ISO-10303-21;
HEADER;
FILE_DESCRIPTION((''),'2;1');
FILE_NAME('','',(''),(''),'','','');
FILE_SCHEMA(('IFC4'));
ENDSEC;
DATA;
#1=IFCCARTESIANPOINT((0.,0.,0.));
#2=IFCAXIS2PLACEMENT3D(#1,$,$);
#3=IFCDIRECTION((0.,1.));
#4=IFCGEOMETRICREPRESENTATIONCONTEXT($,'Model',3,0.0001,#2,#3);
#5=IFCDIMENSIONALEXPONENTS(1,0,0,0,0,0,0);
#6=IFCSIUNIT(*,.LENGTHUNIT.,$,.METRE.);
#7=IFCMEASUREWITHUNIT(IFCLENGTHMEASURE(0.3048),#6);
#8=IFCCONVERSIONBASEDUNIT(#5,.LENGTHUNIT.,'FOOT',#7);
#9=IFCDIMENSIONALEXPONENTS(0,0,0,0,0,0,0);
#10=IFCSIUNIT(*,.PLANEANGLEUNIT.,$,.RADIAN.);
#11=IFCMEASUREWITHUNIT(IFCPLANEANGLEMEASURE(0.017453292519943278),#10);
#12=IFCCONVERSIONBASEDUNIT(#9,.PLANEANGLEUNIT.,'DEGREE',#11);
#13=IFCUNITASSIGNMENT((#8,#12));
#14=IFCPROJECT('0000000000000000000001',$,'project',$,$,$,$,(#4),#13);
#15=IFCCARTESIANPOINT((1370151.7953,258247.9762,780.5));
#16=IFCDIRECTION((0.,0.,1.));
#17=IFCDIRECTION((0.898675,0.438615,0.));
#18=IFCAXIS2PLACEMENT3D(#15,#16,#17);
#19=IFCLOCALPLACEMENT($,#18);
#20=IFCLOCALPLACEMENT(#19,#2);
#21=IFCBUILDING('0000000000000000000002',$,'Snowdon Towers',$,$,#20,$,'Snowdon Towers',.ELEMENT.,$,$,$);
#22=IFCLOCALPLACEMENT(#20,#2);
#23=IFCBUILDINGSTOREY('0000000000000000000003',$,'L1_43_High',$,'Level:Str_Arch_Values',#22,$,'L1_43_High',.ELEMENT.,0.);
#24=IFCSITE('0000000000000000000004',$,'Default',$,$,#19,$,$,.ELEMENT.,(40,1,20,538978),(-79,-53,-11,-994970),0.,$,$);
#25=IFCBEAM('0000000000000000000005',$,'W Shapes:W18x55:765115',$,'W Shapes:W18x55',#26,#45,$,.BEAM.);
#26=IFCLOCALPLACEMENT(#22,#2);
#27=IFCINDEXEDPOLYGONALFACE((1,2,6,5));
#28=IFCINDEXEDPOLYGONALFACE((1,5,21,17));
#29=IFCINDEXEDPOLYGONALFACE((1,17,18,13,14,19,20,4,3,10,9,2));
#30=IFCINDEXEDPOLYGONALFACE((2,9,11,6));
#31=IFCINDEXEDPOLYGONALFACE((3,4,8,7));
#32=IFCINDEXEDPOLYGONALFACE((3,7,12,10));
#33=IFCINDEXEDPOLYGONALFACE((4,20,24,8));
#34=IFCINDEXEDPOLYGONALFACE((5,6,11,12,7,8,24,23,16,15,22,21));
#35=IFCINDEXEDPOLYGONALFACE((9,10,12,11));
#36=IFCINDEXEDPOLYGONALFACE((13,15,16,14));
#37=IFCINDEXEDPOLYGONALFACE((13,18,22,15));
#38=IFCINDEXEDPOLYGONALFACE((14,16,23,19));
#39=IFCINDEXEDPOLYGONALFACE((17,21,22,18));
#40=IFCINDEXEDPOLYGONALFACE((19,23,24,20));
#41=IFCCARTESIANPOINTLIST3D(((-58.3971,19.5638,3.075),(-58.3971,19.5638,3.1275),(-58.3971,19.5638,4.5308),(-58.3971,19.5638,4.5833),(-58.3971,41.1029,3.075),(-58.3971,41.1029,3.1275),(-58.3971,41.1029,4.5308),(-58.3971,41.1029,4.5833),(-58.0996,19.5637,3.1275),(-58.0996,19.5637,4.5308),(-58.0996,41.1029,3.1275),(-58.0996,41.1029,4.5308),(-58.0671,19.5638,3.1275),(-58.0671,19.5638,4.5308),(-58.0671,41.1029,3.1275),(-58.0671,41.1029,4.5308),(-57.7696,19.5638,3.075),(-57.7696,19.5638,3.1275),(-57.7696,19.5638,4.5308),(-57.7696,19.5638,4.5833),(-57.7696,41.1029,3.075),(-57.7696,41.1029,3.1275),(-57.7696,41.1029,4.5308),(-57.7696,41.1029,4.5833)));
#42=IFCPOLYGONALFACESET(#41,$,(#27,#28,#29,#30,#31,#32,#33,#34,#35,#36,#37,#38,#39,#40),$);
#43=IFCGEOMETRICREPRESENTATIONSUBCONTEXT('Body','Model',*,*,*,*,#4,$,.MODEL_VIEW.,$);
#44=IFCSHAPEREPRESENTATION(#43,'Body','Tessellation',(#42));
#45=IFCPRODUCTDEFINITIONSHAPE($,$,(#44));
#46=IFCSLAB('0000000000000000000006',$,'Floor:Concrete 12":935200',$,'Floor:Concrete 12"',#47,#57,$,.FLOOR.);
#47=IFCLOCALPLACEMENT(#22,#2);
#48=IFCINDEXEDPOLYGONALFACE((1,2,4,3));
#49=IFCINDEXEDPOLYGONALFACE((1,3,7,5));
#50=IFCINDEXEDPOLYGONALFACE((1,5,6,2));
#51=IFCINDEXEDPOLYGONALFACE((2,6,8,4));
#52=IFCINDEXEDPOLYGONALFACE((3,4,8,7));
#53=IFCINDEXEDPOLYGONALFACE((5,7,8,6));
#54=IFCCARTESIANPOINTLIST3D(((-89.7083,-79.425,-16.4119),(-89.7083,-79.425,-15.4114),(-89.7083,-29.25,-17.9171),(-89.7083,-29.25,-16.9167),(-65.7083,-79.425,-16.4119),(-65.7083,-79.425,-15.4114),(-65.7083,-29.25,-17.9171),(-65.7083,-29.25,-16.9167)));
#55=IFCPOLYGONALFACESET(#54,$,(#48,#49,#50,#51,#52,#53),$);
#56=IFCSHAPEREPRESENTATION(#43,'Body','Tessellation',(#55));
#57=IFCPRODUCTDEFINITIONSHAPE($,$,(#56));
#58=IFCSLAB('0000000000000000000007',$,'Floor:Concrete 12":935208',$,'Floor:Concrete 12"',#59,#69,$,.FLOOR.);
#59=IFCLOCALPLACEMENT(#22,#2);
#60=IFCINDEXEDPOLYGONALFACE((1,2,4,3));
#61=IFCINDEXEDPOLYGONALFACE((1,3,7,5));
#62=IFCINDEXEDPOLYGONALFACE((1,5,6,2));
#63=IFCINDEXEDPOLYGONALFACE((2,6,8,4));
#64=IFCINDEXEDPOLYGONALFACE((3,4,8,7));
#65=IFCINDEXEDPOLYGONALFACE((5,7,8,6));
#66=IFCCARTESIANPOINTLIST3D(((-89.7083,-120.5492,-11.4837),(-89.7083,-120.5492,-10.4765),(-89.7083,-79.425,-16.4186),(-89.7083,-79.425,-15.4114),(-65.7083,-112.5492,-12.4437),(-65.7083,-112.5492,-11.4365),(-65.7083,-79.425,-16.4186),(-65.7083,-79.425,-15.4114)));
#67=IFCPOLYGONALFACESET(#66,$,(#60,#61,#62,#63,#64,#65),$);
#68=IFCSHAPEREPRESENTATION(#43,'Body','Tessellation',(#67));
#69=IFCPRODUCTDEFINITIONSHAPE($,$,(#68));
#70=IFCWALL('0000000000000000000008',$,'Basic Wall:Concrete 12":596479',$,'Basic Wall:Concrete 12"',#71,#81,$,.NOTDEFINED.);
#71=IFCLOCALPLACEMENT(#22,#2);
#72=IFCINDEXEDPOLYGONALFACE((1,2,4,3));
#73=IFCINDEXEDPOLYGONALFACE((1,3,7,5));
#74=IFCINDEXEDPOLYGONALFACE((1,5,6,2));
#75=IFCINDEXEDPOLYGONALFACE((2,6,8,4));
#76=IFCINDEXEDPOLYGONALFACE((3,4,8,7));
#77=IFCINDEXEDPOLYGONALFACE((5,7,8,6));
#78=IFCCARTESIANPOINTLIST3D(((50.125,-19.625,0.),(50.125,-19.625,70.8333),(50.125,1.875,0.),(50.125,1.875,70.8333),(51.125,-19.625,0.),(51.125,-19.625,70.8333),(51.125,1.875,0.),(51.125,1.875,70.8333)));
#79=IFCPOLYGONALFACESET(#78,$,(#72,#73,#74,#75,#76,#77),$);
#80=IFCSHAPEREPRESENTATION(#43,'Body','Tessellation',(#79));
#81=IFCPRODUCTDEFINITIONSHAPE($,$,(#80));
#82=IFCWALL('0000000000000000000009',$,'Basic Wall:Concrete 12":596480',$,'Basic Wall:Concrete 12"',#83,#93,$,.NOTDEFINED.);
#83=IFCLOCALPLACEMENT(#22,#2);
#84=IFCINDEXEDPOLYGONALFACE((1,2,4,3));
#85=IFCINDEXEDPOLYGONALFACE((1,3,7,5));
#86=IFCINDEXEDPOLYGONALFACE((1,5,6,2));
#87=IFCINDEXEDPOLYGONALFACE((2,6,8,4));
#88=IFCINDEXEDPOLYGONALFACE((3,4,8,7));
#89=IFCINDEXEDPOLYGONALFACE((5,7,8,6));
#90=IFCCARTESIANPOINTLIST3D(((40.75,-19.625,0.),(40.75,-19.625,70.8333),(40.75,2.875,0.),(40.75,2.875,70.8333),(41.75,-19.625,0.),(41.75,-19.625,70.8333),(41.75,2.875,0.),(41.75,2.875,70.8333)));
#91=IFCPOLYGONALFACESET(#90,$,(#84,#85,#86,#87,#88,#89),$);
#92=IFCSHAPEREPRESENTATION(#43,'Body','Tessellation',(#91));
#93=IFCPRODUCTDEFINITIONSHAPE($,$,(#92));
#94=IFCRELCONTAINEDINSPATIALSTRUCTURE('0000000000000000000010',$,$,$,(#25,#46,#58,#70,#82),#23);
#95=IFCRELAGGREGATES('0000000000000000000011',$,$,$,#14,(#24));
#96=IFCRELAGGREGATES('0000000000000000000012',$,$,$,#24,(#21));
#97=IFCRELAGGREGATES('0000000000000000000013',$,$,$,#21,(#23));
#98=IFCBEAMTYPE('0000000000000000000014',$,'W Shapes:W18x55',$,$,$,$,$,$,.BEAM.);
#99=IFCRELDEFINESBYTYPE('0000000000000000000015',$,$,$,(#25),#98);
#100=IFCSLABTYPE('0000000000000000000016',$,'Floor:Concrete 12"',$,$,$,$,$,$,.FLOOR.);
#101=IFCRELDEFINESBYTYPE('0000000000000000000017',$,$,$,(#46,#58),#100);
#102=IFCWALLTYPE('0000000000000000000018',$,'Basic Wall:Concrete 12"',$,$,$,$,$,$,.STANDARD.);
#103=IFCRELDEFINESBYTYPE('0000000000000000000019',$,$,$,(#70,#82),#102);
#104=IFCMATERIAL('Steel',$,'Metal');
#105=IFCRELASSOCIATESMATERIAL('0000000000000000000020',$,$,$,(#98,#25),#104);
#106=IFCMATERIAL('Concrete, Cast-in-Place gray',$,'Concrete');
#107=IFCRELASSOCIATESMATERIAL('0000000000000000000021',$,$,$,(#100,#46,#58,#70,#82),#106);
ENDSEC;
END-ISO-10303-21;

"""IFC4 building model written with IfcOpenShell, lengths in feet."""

from ifc_helpers import new_model, entity, si_unit, converted_unit, direction, frame, frame_2d, origin, place, context, subcontext, project, spatial, polyline, indexed_curve, rectangle, outline, extrude, source, transform, mapped, material, type_object, type_shapes, element, save


model = new_model("IFC4")

# Units and contexts
model_context = context("Model", 3, precision=0.0001, world=origin(), true_north=direction((0.0, 1.0)))
body_context = subcontext(model_context, "Body", "Model", "MODEL_VIEW")
ifc_project = project(units=[converted_unit("LENGTHUNIT", "FOOT", entity("IfcLengthMeasure", 0.3048), si_unit("LENGTHUNIT", "METRE"), dimensions=[1, 0, 0, 0, 0, 0, 0]), converted_unit("PLANEANGLEUNIT", "DEGREE", entity("IfcPlaneAngleMeasure", 0.017453292519943278), si_unit("PLANEANGLEUNIT", "RADIAN"), dimensions=[0, 0, 0, 0, 0, 0, 0])], contexts=[model_context])

# Site, building, storey
site_placement = place(None, frame((1370151.7953, 258247.9762, 780.5), z_axis=(0.0, 0.0, 1.0), x_axis=(0.898675, 0.438615, 0.0)))
site = spatial("IfcSite", under=ifc_project, at=site_placement, Name="Default", CompositionType="ELEMENT", RefLatitude=(40, 1, 20, 538978), RefLongitude=(-79, -53, -11, -994970), RefElevation=0.0)
building_placement = place(site_placement, origin())
building = spatial("IfcBuilding", under=site, at=building_placement, Name="Snowdon Towers", LongName="Snowdon Towers", CompositionType="ELEMENT")
storey_placement = place(building_placement, origin())
storey = spatial("IfcBuildingStorey", under=building, at=storey_placement, Name="L1_43_High", ObjectType="Level:Str_Arch_Values", LongName="L1_43_High", CompositionType="ELEMENT", Elevation=0.0)

# Shared definitions
ifc_material_1 = material(Name="Steel", Category="Metal")

# Shared definitions
ifc_material_2 = material(Name="Concrete, Cast-in-Place gray", Category="Concrete")

# Beam
beam_type_1 = type_object("IfcBeamType", Name="W Shapes:W18x55", PredefinedType="BEAM", material=ifc_material_1)
shared_shape_1 = source(origin(), body_context, "Body", "SweptSolid", [
    extrude(outline(indexed_curve([(-0.3138, -0.7017), (-0.3138, -0.7542), (0.3138, -0.7542), (0.3138, -0.7017), (0.0162, -0.7017), (0.0162, 0.7017), (0.3138, 0.7017), (0.3138, 0.7542), (-0.3137, 0.7542), (-0.3137, 0.7017), (-0.0163, 0.7017), (-0.0163, -0.7017), (-0.3138, -0.7017)], self_intersect=False)), frame((-10.7696, 0.0, 0.0), z_axis=(-1.0, 0.0, 0.0), x_axis=(0.0, -1.0, 0.0)), (0.0, 0.0, -1.0), 21.5392),
])
type_shapes(beam_type_1, [shared_shape_1])
beam_1_placement = place(storey_placement, frame((-58.0833, 30.3333, 3.8292), z_axis=(0.0, 0.0, 1.0), x_axis=(0.0, 1.0, 0.0)))
element("IfcBeam", 1, at=beam_1_placement, inside=storey, type_object=beam_type_1, material=ifc_material_1, Name="W Shapes:W18x55:765115", ObjectType="W Shapes:W18x55", PredefinedType="BEAM", context=body_context, shape_type="MappedRepresentation", body=[
    mapped(shared_shape_1, transform((0.0, 0.0, 0.0), scale=1.0)),
])

# Slabs
slab_type_1 = type_object("IfcSlabType", Name="Floor:Concrete 12\"", PredefinedType="FLOOR", material=ifc_material_2)
slab_1_placement = place(storey_placement, frame((-89.7083, -79.425, -17.9171)))
element("IfcSlab", 2, at=slab_1_placement, inside=storey, type_object=slab_type_1, material=ifc_material_2, Name="Floor:Concrete 12\":935200", ObjectType="Floor:Concrete 12\"", PredefinedType="FLOOR", context=body_context, shape_type="SweptSolid", body=[
    extrude(rectangle(XDim=24.0, YDim=50.1976, at=frame_2d((0.0, -25.0988), x_axis=(1.0, 0.0))), frame((12.0, 50.175, 1.0004), z_axis=(0.0, 0.029987, 0.99955), x_axis=(1.0, 0.0, 0.0)), (0.0, 0.029987, -0.99955), 1.0004),
])
slab_2_placement = place(storey_placement, frame((-89.7083, -120.5492, -16.4186)))
element("IfcSlab", 3, at=slab_2_placement, inside=storey, type_object=slab_type_1, material=ifc_material_2, Name="Floor:Concrete 12\":935208", ObjectType="Floor:Concrete 12\"", PredefinedType="FLOOR", context=body_context, shape_type="SweptSolid", body=[
    extrude(outline(polyline([(-12.0, -41.4193), (12.0, -33.3619), (12.0, 0.0), (-12.0, 0.0), (-12.0, -41.4193)])), frame((12.0, 41.1242, 1.0072), z_axis=(0.0, 0.119145, 0.992877), x_axis=(1.0, 0.0, 0.0)), (0.0, 0.119145, -0.992877), 1.0072),
])

# Walls
wall_type = type_object("IfcWallType", Name="Basic Wall:Concrete 12\"", PredefinedType="STANDARD")
wall_1_placement = place(storey_placement, frame((50.625, -19.625, 0.0), z_axis=(0.0, 0.0, 1.0), x_axis=(0.0, 1.0, 0.0)))
element("IfcWall", 4, at=wall_1_placement, inside=storey, type_object=wall_type, material=ifc_material_2, Name="Basic Wall:Concrete 12\":596479", ObjectType="Basic Wall:Concrete 12\"", PredefinedType="NOTDEFINED", context=body_context, shape_type="SweptSolid", body=[
    extrude(outline(indexed_curve([(21.5, 0.5), (0.0, 0.5), (0.0, -0.5), (21.5, -0.5), (21.5, 0.5)], self_intersect=False)), origin(), (0.0, 0.0, 1.0), 70.8333),
])
wall_2_placement = place(storey_placement, frame((41.25, 2.875, 0.0), z_axis=(0.0, 0.0, 1.0), x_axis=(0.0, -1.0, 0.0)))
element("IfcWall", 5, at=wall_2_placement, inside=storey, type_object=wall_type, material=ifc_material_2, Name="Basic Wall:Concrete 12\":596480", ObjectType="Basic Wall:Concrete 12\"", PredefinedType="NOTDEFINED", context=body_context, shape_type="SweptSolid", body=[
    extrude(outline(indexed_curve([(22.5, 0.5), (0.0, 0.5), (0.0, -0.5), (22.5, -0.5), (22.5, 0.5)], self_intersect=False)), origin(), (0.0, 0.0, 1.0), 70.8333),
])

save(model, "model.ifc")
